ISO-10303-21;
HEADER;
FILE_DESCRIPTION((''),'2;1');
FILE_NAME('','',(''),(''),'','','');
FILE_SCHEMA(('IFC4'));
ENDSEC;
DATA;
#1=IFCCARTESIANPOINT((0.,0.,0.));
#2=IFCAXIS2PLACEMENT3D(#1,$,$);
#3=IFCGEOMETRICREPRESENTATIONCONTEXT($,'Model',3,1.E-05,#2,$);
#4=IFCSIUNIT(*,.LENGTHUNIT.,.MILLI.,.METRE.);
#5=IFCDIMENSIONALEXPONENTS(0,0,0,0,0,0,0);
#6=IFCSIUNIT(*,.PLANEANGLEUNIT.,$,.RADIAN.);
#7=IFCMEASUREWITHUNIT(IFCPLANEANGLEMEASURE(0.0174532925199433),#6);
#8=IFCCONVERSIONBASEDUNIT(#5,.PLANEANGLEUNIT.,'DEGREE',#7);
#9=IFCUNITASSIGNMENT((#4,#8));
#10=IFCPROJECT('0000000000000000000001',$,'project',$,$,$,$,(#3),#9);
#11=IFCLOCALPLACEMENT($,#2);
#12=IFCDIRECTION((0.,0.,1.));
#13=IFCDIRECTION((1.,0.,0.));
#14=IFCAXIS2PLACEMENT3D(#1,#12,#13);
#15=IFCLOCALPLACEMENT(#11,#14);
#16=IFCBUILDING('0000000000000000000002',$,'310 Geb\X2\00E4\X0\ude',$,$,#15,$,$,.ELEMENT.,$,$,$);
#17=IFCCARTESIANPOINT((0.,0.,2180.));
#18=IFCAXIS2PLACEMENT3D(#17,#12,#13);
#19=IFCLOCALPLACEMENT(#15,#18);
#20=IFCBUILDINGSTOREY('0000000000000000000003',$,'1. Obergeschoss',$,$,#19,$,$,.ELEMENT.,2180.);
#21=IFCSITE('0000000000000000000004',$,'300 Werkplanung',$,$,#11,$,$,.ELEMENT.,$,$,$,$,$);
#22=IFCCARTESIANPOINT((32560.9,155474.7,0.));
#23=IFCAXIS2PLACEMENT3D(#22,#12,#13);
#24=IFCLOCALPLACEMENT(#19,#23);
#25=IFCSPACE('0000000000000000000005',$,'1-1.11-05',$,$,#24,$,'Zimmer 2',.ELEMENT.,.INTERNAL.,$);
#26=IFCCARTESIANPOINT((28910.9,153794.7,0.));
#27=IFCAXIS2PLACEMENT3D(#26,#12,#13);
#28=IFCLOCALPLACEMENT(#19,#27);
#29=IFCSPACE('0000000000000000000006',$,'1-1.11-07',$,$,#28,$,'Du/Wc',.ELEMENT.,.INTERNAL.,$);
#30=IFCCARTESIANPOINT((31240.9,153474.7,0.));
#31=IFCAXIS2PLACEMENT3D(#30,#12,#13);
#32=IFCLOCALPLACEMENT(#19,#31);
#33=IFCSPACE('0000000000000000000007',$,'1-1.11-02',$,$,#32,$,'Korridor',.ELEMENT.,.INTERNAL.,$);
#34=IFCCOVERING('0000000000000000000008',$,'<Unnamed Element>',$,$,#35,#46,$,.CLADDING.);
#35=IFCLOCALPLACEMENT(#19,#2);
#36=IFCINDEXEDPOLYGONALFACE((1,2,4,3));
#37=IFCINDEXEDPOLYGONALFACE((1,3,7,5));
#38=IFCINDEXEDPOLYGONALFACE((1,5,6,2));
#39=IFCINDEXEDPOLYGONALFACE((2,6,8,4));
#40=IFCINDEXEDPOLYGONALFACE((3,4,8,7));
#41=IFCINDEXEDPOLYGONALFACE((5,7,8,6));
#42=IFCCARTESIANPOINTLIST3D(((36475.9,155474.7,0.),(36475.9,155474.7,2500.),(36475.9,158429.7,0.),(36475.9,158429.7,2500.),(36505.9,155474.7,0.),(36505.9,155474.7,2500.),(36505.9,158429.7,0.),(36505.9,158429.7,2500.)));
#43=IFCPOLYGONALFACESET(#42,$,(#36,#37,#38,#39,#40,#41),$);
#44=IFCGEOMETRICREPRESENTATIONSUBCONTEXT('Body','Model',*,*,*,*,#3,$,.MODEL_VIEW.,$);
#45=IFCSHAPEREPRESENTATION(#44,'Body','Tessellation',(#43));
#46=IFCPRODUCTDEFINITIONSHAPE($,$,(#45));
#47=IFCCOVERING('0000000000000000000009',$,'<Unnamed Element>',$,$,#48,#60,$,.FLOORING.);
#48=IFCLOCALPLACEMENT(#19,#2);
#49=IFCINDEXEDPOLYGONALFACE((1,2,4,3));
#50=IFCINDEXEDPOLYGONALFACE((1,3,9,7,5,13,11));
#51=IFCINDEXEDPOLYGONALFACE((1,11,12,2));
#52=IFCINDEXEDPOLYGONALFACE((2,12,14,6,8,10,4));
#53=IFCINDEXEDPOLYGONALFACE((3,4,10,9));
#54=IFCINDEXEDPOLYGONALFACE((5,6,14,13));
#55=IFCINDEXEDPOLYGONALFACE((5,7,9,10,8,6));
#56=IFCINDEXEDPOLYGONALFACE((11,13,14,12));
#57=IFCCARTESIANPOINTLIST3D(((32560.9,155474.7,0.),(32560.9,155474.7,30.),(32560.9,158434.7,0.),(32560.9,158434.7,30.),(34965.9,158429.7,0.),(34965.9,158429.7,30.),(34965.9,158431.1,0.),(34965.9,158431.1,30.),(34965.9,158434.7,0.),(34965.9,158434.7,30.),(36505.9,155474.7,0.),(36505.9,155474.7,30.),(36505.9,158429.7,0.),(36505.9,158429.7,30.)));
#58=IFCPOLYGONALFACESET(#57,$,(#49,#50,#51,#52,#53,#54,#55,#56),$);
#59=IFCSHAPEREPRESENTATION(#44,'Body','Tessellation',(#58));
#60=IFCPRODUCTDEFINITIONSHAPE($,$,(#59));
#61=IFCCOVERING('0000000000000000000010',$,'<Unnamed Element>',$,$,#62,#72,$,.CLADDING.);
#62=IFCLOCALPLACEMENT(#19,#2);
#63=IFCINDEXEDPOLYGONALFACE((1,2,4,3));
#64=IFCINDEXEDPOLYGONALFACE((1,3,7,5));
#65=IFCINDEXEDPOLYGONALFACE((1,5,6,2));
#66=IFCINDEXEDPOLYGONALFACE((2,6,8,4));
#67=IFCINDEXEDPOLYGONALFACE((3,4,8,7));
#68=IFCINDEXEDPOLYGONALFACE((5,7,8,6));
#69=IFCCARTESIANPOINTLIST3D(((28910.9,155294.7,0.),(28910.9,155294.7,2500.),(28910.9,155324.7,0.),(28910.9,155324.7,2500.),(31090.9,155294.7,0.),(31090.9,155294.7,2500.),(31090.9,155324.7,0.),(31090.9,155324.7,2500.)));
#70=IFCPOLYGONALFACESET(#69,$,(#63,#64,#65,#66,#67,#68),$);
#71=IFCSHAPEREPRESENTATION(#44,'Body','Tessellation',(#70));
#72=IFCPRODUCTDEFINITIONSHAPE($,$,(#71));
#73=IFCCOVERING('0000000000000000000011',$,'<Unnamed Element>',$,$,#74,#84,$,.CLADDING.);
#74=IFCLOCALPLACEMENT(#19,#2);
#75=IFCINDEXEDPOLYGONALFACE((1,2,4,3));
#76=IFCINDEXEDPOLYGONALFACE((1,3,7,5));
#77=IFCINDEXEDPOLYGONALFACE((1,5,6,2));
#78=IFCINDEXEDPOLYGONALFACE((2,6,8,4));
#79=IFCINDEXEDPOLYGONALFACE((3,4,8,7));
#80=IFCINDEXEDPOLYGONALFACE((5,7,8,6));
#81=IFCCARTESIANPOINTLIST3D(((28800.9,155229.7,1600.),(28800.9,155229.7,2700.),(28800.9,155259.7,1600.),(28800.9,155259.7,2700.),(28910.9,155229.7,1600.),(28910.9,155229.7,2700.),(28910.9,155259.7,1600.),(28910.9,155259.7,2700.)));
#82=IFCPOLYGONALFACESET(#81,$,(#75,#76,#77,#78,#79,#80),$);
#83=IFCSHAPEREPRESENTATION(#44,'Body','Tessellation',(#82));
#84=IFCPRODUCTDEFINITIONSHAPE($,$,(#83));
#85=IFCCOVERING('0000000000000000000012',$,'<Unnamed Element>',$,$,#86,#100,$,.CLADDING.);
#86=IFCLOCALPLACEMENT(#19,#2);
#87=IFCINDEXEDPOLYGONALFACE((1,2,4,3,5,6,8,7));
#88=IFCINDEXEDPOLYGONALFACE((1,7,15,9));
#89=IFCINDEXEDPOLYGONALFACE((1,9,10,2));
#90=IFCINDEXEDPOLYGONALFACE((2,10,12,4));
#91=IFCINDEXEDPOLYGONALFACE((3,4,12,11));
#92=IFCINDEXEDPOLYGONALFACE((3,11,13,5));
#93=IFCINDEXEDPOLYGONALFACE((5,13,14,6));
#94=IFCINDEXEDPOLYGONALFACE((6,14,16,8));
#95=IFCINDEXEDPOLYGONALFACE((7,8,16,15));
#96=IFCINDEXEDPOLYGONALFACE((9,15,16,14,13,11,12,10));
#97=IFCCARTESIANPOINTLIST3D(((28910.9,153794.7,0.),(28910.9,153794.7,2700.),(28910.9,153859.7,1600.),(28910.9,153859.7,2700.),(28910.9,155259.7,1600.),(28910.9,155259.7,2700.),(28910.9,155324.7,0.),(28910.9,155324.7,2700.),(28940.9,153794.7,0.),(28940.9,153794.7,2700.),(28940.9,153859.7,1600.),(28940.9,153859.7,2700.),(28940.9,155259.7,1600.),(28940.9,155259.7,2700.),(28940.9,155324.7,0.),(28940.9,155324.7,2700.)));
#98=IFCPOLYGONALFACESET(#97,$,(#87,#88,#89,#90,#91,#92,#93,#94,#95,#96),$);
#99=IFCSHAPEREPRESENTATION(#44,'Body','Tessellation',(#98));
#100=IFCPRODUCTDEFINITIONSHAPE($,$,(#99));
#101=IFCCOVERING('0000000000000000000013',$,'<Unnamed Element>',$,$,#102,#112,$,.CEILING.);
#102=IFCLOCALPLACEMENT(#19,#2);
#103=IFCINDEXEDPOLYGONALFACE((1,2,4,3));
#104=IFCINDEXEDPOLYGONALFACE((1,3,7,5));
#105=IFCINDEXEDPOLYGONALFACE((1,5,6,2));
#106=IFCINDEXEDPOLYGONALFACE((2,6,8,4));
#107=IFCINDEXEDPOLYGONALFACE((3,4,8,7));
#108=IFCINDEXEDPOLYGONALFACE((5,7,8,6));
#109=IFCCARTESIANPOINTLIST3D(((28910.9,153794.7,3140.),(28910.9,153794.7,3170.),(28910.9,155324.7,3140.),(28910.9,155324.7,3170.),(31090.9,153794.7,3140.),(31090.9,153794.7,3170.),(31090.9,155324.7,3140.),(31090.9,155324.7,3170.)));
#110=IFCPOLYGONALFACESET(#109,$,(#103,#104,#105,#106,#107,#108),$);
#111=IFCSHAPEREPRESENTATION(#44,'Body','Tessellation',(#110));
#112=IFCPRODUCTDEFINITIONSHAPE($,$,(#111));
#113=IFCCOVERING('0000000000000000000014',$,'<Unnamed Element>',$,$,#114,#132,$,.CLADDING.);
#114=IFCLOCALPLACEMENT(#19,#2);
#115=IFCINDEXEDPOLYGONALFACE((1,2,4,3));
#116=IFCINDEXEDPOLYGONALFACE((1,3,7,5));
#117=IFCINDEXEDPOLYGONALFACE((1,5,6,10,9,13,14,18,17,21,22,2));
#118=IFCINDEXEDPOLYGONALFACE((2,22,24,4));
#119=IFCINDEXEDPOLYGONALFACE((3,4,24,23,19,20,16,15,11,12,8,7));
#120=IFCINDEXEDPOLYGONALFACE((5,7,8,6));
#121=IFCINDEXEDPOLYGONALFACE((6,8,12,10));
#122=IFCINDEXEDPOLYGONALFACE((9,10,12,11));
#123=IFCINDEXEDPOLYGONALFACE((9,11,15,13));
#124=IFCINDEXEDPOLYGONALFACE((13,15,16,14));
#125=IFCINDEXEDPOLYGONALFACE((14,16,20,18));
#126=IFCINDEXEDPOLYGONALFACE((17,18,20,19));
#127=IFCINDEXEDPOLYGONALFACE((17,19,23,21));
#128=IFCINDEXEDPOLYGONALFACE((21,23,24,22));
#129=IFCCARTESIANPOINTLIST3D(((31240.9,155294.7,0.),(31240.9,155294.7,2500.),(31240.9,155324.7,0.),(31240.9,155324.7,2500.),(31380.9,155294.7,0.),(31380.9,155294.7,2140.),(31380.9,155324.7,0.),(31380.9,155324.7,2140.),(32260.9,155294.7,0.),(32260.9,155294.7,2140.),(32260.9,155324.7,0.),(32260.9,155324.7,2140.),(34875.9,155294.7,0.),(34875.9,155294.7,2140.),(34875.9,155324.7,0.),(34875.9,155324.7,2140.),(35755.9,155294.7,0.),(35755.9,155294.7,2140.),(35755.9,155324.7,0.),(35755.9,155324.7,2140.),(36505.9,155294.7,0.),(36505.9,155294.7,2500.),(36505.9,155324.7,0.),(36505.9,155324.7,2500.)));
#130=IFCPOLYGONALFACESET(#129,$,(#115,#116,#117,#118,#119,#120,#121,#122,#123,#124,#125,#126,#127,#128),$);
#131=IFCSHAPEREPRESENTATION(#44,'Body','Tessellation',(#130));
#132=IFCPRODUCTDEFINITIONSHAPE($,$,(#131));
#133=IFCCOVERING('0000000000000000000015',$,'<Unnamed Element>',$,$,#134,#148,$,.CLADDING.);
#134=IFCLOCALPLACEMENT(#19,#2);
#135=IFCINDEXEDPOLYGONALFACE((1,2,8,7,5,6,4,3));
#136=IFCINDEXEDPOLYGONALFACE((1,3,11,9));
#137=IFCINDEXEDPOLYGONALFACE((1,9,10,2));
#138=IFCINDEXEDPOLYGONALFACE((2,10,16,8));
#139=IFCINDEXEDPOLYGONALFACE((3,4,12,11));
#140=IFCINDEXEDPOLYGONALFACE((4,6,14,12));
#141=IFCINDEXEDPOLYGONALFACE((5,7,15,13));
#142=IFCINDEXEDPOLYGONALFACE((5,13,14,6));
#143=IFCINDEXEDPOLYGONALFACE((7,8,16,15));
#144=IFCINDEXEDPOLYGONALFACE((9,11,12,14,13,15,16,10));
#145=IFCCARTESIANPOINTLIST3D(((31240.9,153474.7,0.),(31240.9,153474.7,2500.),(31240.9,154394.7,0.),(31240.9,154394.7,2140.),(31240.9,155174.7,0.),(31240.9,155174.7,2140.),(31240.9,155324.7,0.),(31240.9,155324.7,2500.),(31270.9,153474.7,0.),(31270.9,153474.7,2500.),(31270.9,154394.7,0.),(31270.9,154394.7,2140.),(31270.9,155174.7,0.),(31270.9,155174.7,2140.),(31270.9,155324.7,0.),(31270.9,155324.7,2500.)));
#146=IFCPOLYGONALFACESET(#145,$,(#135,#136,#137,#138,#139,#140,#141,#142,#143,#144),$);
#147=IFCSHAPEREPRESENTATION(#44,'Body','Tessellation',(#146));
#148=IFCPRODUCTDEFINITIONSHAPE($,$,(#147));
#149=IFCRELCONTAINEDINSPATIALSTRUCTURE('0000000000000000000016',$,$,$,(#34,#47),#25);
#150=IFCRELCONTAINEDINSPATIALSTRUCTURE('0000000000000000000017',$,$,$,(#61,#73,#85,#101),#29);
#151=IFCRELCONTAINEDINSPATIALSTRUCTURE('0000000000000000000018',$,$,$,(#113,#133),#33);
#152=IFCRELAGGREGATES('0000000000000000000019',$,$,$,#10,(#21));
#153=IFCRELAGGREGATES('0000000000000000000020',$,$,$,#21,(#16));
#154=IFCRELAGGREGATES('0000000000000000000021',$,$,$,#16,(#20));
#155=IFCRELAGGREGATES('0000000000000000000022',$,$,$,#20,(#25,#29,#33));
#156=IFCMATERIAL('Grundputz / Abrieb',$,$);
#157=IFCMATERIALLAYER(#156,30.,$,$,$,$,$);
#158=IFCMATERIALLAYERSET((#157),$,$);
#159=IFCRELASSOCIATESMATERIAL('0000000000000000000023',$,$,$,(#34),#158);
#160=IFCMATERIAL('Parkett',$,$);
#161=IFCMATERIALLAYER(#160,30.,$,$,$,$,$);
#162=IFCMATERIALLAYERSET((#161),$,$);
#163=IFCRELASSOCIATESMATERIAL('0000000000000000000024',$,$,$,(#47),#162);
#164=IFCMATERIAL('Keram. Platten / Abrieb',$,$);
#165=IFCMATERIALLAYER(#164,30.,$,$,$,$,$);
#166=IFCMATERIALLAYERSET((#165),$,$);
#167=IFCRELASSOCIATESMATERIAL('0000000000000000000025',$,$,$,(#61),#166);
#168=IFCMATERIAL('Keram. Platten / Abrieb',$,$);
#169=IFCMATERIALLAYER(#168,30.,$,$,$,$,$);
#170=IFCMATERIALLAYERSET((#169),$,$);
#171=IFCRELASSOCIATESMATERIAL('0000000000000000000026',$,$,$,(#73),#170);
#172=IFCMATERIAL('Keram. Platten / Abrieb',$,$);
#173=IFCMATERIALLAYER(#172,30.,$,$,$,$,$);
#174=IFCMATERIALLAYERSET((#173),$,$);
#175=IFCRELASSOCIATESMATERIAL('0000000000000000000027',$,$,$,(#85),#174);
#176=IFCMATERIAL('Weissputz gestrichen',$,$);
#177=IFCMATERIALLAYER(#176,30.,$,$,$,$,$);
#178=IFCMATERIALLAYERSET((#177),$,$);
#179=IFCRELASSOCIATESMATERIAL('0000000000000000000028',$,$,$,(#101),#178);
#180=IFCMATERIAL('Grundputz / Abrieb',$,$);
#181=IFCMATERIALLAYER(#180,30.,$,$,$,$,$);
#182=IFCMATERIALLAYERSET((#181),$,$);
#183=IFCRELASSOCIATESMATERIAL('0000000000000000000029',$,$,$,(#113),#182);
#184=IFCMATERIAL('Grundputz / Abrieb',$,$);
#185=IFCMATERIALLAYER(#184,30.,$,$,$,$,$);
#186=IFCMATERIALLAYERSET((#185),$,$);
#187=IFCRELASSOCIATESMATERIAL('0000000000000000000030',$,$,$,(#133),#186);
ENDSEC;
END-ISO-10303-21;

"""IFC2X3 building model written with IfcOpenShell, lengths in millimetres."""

from ifc_helpers import new_model, entity, si_unit, converted_unit, frame, frame_2d, origin, origin_with_axes, place, context, subcontext, project, spatial, polyline, rectangle, outline, extrude, material, layer, layer_set, layer_usage, element, save


model = new_model("IFC2X3")

# Units and contexts
model_context = context("Model", 3, precision=1e-05, world=origin())
body_context = subcontext(model_context, "Body", "Model", "MODEL_VIEW")
ifc_project = project(units=[si_unit("LENGTHUNIT", "METRE", prefix="MILLI"), converted_unit("PLANEANGLEUNIT", "DEGREE", entity("IfcPlaneAngleMeasure", 0.0174532925199433), si_unit("PLANEANGLEUNIT", "RADIAN"), dimensions=[0, 0, 0, 0, 0, 0, 0])], contexts=[model_context])

# Site, building, storey
site_placement = place(None, origin())
site = spatial("IfcSite", under=ifc_project, at=site_placement, Name="300 Werkplanung", CompositionType="ELEMENT")
building_placement = place(site_placement, origin_with_axes())
building = spatial("IfcBuilding", under=site, at=building_placement, Name="310 Gebäude", CompositionType="ELEMENT")
storey_placement = place(building_placement, frame((0.0, 0.0, 2180.0), z_axis=(0.0, 0.0, 1.0), x_axis=(1.0, 0.0, 0.0)))
storey = spatial("IfcBuildingStorey", under=building, at=storey_placement, Name="1. Obergeschoss", CompositionType="ELEMENT", Elevation=2180.0)

# Shared definitions
space_1_placement = place(storey_placement, frame((32560.9, 155474.7, 0.0), z_axis=(0.0, 0.0, 1.0), x_axis=(1.0, 0.0, 0.0)))
space_1 = spatial("IfcSpace", under=storey, at=space_1_placement, Name="1-1.11-05", LongName="Zimmer 2", CompositionType="ELEMENT", InteriorOrExteriorSpace="INTERNAL")

# Coverings
ifc_material_1 = material(Name="Grundputz / Abrieb")
ifc_layer_1 = layer(ifc_material_1, 30.0)
ifc_layer_set_1 = layer_set([ifc_layer_1])
ifc_layer_usage_1 = layer_usage(ifc_layer_set_1, "AXIS3", "POSITIVE", 0.0)
covering_1_placement = place(space_1_placement, frame((3945.0, 0.0, 0.0), z_axis=(0.0, 0.0, 1.0), x_axis=(0.0, 1.0, 0.0)))
element("IfcCovering", 1, at=covering_1_placement, inside=space_1, material=ifc_layer_usage_1, Name="<Unnamed Element>", PredefinedType="CLADDING", context=body_context, shape_type="SweptSolid", body=[
    extrude(rectangle(XDim=2500.0, YDim=2955.0, at=frame_2d((-1477.5, 1250.0), x_axis=(0.0, 1.0))), frame((2955.0, 0.0, 2500.0), z_axis=(0.0, 1.0, 0.0), x_axis=(1.0, 0.0, 0.0)), (0.0, 0.0, 1.0), 30.0),
])
ifc_material_2 = material(Name="Parkett")
ifc_layer_2 = layer(ifc_material_2, 30.0)
ifc_layer_set_2 = layer_set([ifc_layer_2])
ifc_layer_usage_2 = layer_usage(ifc_layer_set_2, "AXIS3", "POSITIVE", 0.0)
covering_2_placement = place(space_1_placement, origin_with_axes())
element("IfcCovering", 2, at=covering_2_placement, inside=space_1, material=ifc_layer_usage_2, Name="<Unnamed Element>", PredefinedType="FLOORING", context=body_context, shape_type="SweptSolid", body=[
    extrude(outline(polyline([(2405.0, 2960.0), (0.0, 2960.0), (0.0, 0.0), (3945.0, 0.0), (3945.0, 2955.0), (2405.0, 2955.0), (2405.0, 2956.4), (2405.0, 2960.0)])), origin_with_axes(), (0.0, 0.0, 1.0), 30.0),
])

# Shared definitions
space_2_placement = place(storey_placement, frame((28910.9, 153794.7, 0.0), z_axis=(0.0, 0.0, 1.0), x_axis=(1.0, 0.0, 0.0)))
space_2 = spatial("IfcSpace", under=storey, at=space_2_placement, Name="1-1.11-07", LongName="Du/Wc", CompositionType="ELEMENT", InteriorOrExteriorSpace="INTERNAL")

# Coverings
ifc_material_3 = material(Name="Keram. Platten / Abrieb")
ifc_layer_3 = layer(ifc_material_3, 30.0)
ifc_layer_set_3 = layer_set([ifc_layer_3])
ifc_layer_usage_3 = layer_usage(ifc_layer_set_3, "AXIS3", "POSITIVE", 0.0)
covering_3_placement = place(space_2_placement, frame((2180.0, 1530.0, 0.0), z_axis=(0.0, 0.0, 1.0), x_axis=(-1.0, 0.0, 0.0)))
element("IfcCovering", 3, at=covering_3_placement, inside=space_2, material=ifc_layer_usage_3, Name="<Unnamed Element>", PredefinedType="CLADDING", context=body_context, shape_type="SweptSolid", body=[
    extrude(rectangle(XDim=2500.0, YDim=2180.0, at=frame_2d((-1090.0, 1250.0), x_axis=(0.0, 1.0))), frame((2180.0, 0.0, 2500.0), z_axis=(0.0, 1.0, 0.0), x_axis=(1.0, 0.0, 0.0)), (0.0, 0.0, 1.0), 30.0),
])
ifc_material_4 = material(Name="Keram. Platten / Abrieb")
ifc_layer_4 = layer(ifc_material_4, 30.0)
ifc_layer_set_4 = layer_set([ifc_layer_4])
ifc_layer_usage_4 = layer_usage(ifc_layer_set_4, "AXIS3", "POSITIVE", 0.0)
covering_4_placement = place(space_2_placement, frame((0.0, 1465.0, 1600.0), z_axis=(0.0, 0.0, 1.0), x_axis=(-1.0, 0.0, 0.0)))
element("IfcCovering", 4, at=covering_4_placement, inside=space_2, material=ifc_layer_usage_4, Name="<Unnamed Element>", PredefinedType="CLADDING", context=body_context, shape_type="SweptSolid", body=[
    extrude(rectangle(XDim=1100.0, YDim=110.0, at=frame_2d((-55.0, 550.0), x_axis=(0.0, 1.0))), frame((110.0, 0.0, 1100.0), z_axis=(0.0, 1.0, 0.0), x_axis=(1.0, 0.0, 0.0)), (0.0, 0.0, 1.0), 30.0),
])
ifc_material_5 = material(Name="Keram. Platten / Abrieb")
ifc_layer_5 = layer(ifc_material_5, 30.0)
ifc_layer_set_5 = layer_set([ifc_layer_5])
ifc_layer_usage_5 = layer_usage(ifc_layer_set_5, "AXIS3", "POSITIVE", 0.0)
covering_5_placement = place(space_2_placement, frame((0.0, 1530.0, 0.0), z_axis=(0.0, 0.0, 1.0), x_axis=(0.0, -1.0, 0.0)))
element("IfcCovering", 5, at=covering_5_placement, inside=space_2, material=ifc_layer_usage_5, Name="<Unnamed Element>", PredefinedType="CLADDING", context=body_context, shape_type="SweptSolid", body=[
    extrude(outline(polyline([(1530.0, 0.0), (1530.0, -2700.0), (1465.0, -2700.0), (1465.0, -1600.0), (65.0, -1600.0), (65.0, -2700.0), (0.0, -2700.0), (0.0, 0.0), (1530.0, 0.0)])), frame((0.0, 0.0, 0.0), z_axis=(0.0, 1.0, 0.0), x_axis=(1.0, 0.0, 0.0)), (0.0, 0.0, 1.0), 30.0),
])
ifc_material_6 = material(Name="Weissputz gestrichen")
ifc_layer_6 = layer(ifc_material_6, 30.0)
ifc_layer_set_6 = layer_set([ifc_layer_6])
ifc_layer_usage_6 = layer_usage(ifc_layer_set_6, "AXIS3", "POSITIVE", 0.0)
covering_6_placement = place(space_2_placement, frame((1090.0, 765.0, 3170.0), z_axis=(0.0, 0.0, -1.0), x_axis=(1.0, 0.0, 0.0)))
element("IfcCovering", 6, at=covering_6_placement, inside=space_2, material=ifc_layer_usage_6, Name="<Unnamed Element>", PredefinedType="CEILING", context=body_context, shape_type="SweptSolid", body=[
    extrude(rectangle(XDim=2180.0, YDim=1530.0, at=frame_2d((1090.0, 765.0), x_axis=(1.0, 0.0))), frame((-1090.0, -765.0, 0.0), z_axis=(0.0, 0.0, 1.0), x_axis=(1.0, 0.0, 0.0)), (0.0, 0.0, 1.0), 30.0),
])

# Shared definitions
space_3_placement = place(storey_placement, frame((31240.9, 153474.7, 0.0), z_axis=(0.0, 0.0, 1.0), x_axis=(1.0, 0.0, 0.0)))
space_3 = spatial("IfcSpace", under=storey, at=space_3_placement, Name="1-1.11-02", LongName="Korridor", CompositionType="ELEMENT", InteriorOrExteriorSpace="INTERNAL")

# Coverings
ifc_material_7 = material(Name="Grundputz / Abrieb")
ifc_layer_7 = layer(ifc_material_7, 30.0)
ifc_layer_set_7 = layer_set([ifc_layer_7])
ifc_layer_usage_7 = layer_usage(ifc_layer_set_7, "AXIS3", "POSITIVE", 0.0)
covering_7_placement = place(space_3_placement, frame((5265.0, 1850.0, 0.0), z_axis=(0.0, 0.0, 1.0), x_axis=(-1.0, 0.0, 0.0)))
element("IfcCovering", 7, at=covering_7_placement, inside=space_3, material=ifc_layer_usage_7, Name="<Unnamed Element>", PredefinedType="CLADDING", context=body_context, shape_type="SweptSolid", body=[
    extrude(outline(polyline([(5265.0, 0.0), (5265.0, -2500.0), (0.0, -2500.0), (0.0, 0.0), (750.0, 0.0), (750.0, -2140.0), (1630.0, -2140.0), (1630.0, 0.0), (4245.0, 0.0), (4245.0, -2140.0), (5125.0, -2140.0), (5125.0, 0.0), (5265.0, 0.0)])), frame((0.0, 0.0, 0.0), z_axis=(0.0, 1.0, 0.0), x_axis=(1.0, 0.0, 0.0)), (0.0, 0.0, 1.0), 30.0),
])
ifc_material_8 = material(Name="Grundputz / Abrieb")
ifc_layer_8 = layer(ifc_material_8, 30.0)
ifc_layer_set_8 = layer_set([ifc_layer_8])
ifc_layer_usage_8 = layer_usage(ifc_layer_set_8, "AXIS3", "POSITIVE", 0.0)
covering_8_placement = place(space_3_placement, frame((0.0, 1850.0, 0.0), z_axis=(0.0, 0.0, 1.0), x_axis=(0.0, -1.0, 0.0)))
element("IfcCovering", 8, at=covering_8_placement, inside=space_3, material=ifc_layer_usage_8, Name="<Unnamed Element>", PredefinedType="CLADDING", context=body_context, shape_type="SweptSolid", body=[
    extrude(outline(polyline([(1850.0, 0.0), (1850.0, -2500.0), (0.0, -2500.0), (0.0, 0.0), (150.0, 0.0), (150.0, -2140.0), (930.0, -2140.0), (930.0, 0.0), (1850.0, 0.0)])), frame((0.0, 0.0, 0.0), z_axis=(0.0, 1.0, 0.0), x_axis=(1.0, 0.0, 0.0)), (0.0, 0.0, 1.0), 30.0),
])

save(model, "model.ifc")
